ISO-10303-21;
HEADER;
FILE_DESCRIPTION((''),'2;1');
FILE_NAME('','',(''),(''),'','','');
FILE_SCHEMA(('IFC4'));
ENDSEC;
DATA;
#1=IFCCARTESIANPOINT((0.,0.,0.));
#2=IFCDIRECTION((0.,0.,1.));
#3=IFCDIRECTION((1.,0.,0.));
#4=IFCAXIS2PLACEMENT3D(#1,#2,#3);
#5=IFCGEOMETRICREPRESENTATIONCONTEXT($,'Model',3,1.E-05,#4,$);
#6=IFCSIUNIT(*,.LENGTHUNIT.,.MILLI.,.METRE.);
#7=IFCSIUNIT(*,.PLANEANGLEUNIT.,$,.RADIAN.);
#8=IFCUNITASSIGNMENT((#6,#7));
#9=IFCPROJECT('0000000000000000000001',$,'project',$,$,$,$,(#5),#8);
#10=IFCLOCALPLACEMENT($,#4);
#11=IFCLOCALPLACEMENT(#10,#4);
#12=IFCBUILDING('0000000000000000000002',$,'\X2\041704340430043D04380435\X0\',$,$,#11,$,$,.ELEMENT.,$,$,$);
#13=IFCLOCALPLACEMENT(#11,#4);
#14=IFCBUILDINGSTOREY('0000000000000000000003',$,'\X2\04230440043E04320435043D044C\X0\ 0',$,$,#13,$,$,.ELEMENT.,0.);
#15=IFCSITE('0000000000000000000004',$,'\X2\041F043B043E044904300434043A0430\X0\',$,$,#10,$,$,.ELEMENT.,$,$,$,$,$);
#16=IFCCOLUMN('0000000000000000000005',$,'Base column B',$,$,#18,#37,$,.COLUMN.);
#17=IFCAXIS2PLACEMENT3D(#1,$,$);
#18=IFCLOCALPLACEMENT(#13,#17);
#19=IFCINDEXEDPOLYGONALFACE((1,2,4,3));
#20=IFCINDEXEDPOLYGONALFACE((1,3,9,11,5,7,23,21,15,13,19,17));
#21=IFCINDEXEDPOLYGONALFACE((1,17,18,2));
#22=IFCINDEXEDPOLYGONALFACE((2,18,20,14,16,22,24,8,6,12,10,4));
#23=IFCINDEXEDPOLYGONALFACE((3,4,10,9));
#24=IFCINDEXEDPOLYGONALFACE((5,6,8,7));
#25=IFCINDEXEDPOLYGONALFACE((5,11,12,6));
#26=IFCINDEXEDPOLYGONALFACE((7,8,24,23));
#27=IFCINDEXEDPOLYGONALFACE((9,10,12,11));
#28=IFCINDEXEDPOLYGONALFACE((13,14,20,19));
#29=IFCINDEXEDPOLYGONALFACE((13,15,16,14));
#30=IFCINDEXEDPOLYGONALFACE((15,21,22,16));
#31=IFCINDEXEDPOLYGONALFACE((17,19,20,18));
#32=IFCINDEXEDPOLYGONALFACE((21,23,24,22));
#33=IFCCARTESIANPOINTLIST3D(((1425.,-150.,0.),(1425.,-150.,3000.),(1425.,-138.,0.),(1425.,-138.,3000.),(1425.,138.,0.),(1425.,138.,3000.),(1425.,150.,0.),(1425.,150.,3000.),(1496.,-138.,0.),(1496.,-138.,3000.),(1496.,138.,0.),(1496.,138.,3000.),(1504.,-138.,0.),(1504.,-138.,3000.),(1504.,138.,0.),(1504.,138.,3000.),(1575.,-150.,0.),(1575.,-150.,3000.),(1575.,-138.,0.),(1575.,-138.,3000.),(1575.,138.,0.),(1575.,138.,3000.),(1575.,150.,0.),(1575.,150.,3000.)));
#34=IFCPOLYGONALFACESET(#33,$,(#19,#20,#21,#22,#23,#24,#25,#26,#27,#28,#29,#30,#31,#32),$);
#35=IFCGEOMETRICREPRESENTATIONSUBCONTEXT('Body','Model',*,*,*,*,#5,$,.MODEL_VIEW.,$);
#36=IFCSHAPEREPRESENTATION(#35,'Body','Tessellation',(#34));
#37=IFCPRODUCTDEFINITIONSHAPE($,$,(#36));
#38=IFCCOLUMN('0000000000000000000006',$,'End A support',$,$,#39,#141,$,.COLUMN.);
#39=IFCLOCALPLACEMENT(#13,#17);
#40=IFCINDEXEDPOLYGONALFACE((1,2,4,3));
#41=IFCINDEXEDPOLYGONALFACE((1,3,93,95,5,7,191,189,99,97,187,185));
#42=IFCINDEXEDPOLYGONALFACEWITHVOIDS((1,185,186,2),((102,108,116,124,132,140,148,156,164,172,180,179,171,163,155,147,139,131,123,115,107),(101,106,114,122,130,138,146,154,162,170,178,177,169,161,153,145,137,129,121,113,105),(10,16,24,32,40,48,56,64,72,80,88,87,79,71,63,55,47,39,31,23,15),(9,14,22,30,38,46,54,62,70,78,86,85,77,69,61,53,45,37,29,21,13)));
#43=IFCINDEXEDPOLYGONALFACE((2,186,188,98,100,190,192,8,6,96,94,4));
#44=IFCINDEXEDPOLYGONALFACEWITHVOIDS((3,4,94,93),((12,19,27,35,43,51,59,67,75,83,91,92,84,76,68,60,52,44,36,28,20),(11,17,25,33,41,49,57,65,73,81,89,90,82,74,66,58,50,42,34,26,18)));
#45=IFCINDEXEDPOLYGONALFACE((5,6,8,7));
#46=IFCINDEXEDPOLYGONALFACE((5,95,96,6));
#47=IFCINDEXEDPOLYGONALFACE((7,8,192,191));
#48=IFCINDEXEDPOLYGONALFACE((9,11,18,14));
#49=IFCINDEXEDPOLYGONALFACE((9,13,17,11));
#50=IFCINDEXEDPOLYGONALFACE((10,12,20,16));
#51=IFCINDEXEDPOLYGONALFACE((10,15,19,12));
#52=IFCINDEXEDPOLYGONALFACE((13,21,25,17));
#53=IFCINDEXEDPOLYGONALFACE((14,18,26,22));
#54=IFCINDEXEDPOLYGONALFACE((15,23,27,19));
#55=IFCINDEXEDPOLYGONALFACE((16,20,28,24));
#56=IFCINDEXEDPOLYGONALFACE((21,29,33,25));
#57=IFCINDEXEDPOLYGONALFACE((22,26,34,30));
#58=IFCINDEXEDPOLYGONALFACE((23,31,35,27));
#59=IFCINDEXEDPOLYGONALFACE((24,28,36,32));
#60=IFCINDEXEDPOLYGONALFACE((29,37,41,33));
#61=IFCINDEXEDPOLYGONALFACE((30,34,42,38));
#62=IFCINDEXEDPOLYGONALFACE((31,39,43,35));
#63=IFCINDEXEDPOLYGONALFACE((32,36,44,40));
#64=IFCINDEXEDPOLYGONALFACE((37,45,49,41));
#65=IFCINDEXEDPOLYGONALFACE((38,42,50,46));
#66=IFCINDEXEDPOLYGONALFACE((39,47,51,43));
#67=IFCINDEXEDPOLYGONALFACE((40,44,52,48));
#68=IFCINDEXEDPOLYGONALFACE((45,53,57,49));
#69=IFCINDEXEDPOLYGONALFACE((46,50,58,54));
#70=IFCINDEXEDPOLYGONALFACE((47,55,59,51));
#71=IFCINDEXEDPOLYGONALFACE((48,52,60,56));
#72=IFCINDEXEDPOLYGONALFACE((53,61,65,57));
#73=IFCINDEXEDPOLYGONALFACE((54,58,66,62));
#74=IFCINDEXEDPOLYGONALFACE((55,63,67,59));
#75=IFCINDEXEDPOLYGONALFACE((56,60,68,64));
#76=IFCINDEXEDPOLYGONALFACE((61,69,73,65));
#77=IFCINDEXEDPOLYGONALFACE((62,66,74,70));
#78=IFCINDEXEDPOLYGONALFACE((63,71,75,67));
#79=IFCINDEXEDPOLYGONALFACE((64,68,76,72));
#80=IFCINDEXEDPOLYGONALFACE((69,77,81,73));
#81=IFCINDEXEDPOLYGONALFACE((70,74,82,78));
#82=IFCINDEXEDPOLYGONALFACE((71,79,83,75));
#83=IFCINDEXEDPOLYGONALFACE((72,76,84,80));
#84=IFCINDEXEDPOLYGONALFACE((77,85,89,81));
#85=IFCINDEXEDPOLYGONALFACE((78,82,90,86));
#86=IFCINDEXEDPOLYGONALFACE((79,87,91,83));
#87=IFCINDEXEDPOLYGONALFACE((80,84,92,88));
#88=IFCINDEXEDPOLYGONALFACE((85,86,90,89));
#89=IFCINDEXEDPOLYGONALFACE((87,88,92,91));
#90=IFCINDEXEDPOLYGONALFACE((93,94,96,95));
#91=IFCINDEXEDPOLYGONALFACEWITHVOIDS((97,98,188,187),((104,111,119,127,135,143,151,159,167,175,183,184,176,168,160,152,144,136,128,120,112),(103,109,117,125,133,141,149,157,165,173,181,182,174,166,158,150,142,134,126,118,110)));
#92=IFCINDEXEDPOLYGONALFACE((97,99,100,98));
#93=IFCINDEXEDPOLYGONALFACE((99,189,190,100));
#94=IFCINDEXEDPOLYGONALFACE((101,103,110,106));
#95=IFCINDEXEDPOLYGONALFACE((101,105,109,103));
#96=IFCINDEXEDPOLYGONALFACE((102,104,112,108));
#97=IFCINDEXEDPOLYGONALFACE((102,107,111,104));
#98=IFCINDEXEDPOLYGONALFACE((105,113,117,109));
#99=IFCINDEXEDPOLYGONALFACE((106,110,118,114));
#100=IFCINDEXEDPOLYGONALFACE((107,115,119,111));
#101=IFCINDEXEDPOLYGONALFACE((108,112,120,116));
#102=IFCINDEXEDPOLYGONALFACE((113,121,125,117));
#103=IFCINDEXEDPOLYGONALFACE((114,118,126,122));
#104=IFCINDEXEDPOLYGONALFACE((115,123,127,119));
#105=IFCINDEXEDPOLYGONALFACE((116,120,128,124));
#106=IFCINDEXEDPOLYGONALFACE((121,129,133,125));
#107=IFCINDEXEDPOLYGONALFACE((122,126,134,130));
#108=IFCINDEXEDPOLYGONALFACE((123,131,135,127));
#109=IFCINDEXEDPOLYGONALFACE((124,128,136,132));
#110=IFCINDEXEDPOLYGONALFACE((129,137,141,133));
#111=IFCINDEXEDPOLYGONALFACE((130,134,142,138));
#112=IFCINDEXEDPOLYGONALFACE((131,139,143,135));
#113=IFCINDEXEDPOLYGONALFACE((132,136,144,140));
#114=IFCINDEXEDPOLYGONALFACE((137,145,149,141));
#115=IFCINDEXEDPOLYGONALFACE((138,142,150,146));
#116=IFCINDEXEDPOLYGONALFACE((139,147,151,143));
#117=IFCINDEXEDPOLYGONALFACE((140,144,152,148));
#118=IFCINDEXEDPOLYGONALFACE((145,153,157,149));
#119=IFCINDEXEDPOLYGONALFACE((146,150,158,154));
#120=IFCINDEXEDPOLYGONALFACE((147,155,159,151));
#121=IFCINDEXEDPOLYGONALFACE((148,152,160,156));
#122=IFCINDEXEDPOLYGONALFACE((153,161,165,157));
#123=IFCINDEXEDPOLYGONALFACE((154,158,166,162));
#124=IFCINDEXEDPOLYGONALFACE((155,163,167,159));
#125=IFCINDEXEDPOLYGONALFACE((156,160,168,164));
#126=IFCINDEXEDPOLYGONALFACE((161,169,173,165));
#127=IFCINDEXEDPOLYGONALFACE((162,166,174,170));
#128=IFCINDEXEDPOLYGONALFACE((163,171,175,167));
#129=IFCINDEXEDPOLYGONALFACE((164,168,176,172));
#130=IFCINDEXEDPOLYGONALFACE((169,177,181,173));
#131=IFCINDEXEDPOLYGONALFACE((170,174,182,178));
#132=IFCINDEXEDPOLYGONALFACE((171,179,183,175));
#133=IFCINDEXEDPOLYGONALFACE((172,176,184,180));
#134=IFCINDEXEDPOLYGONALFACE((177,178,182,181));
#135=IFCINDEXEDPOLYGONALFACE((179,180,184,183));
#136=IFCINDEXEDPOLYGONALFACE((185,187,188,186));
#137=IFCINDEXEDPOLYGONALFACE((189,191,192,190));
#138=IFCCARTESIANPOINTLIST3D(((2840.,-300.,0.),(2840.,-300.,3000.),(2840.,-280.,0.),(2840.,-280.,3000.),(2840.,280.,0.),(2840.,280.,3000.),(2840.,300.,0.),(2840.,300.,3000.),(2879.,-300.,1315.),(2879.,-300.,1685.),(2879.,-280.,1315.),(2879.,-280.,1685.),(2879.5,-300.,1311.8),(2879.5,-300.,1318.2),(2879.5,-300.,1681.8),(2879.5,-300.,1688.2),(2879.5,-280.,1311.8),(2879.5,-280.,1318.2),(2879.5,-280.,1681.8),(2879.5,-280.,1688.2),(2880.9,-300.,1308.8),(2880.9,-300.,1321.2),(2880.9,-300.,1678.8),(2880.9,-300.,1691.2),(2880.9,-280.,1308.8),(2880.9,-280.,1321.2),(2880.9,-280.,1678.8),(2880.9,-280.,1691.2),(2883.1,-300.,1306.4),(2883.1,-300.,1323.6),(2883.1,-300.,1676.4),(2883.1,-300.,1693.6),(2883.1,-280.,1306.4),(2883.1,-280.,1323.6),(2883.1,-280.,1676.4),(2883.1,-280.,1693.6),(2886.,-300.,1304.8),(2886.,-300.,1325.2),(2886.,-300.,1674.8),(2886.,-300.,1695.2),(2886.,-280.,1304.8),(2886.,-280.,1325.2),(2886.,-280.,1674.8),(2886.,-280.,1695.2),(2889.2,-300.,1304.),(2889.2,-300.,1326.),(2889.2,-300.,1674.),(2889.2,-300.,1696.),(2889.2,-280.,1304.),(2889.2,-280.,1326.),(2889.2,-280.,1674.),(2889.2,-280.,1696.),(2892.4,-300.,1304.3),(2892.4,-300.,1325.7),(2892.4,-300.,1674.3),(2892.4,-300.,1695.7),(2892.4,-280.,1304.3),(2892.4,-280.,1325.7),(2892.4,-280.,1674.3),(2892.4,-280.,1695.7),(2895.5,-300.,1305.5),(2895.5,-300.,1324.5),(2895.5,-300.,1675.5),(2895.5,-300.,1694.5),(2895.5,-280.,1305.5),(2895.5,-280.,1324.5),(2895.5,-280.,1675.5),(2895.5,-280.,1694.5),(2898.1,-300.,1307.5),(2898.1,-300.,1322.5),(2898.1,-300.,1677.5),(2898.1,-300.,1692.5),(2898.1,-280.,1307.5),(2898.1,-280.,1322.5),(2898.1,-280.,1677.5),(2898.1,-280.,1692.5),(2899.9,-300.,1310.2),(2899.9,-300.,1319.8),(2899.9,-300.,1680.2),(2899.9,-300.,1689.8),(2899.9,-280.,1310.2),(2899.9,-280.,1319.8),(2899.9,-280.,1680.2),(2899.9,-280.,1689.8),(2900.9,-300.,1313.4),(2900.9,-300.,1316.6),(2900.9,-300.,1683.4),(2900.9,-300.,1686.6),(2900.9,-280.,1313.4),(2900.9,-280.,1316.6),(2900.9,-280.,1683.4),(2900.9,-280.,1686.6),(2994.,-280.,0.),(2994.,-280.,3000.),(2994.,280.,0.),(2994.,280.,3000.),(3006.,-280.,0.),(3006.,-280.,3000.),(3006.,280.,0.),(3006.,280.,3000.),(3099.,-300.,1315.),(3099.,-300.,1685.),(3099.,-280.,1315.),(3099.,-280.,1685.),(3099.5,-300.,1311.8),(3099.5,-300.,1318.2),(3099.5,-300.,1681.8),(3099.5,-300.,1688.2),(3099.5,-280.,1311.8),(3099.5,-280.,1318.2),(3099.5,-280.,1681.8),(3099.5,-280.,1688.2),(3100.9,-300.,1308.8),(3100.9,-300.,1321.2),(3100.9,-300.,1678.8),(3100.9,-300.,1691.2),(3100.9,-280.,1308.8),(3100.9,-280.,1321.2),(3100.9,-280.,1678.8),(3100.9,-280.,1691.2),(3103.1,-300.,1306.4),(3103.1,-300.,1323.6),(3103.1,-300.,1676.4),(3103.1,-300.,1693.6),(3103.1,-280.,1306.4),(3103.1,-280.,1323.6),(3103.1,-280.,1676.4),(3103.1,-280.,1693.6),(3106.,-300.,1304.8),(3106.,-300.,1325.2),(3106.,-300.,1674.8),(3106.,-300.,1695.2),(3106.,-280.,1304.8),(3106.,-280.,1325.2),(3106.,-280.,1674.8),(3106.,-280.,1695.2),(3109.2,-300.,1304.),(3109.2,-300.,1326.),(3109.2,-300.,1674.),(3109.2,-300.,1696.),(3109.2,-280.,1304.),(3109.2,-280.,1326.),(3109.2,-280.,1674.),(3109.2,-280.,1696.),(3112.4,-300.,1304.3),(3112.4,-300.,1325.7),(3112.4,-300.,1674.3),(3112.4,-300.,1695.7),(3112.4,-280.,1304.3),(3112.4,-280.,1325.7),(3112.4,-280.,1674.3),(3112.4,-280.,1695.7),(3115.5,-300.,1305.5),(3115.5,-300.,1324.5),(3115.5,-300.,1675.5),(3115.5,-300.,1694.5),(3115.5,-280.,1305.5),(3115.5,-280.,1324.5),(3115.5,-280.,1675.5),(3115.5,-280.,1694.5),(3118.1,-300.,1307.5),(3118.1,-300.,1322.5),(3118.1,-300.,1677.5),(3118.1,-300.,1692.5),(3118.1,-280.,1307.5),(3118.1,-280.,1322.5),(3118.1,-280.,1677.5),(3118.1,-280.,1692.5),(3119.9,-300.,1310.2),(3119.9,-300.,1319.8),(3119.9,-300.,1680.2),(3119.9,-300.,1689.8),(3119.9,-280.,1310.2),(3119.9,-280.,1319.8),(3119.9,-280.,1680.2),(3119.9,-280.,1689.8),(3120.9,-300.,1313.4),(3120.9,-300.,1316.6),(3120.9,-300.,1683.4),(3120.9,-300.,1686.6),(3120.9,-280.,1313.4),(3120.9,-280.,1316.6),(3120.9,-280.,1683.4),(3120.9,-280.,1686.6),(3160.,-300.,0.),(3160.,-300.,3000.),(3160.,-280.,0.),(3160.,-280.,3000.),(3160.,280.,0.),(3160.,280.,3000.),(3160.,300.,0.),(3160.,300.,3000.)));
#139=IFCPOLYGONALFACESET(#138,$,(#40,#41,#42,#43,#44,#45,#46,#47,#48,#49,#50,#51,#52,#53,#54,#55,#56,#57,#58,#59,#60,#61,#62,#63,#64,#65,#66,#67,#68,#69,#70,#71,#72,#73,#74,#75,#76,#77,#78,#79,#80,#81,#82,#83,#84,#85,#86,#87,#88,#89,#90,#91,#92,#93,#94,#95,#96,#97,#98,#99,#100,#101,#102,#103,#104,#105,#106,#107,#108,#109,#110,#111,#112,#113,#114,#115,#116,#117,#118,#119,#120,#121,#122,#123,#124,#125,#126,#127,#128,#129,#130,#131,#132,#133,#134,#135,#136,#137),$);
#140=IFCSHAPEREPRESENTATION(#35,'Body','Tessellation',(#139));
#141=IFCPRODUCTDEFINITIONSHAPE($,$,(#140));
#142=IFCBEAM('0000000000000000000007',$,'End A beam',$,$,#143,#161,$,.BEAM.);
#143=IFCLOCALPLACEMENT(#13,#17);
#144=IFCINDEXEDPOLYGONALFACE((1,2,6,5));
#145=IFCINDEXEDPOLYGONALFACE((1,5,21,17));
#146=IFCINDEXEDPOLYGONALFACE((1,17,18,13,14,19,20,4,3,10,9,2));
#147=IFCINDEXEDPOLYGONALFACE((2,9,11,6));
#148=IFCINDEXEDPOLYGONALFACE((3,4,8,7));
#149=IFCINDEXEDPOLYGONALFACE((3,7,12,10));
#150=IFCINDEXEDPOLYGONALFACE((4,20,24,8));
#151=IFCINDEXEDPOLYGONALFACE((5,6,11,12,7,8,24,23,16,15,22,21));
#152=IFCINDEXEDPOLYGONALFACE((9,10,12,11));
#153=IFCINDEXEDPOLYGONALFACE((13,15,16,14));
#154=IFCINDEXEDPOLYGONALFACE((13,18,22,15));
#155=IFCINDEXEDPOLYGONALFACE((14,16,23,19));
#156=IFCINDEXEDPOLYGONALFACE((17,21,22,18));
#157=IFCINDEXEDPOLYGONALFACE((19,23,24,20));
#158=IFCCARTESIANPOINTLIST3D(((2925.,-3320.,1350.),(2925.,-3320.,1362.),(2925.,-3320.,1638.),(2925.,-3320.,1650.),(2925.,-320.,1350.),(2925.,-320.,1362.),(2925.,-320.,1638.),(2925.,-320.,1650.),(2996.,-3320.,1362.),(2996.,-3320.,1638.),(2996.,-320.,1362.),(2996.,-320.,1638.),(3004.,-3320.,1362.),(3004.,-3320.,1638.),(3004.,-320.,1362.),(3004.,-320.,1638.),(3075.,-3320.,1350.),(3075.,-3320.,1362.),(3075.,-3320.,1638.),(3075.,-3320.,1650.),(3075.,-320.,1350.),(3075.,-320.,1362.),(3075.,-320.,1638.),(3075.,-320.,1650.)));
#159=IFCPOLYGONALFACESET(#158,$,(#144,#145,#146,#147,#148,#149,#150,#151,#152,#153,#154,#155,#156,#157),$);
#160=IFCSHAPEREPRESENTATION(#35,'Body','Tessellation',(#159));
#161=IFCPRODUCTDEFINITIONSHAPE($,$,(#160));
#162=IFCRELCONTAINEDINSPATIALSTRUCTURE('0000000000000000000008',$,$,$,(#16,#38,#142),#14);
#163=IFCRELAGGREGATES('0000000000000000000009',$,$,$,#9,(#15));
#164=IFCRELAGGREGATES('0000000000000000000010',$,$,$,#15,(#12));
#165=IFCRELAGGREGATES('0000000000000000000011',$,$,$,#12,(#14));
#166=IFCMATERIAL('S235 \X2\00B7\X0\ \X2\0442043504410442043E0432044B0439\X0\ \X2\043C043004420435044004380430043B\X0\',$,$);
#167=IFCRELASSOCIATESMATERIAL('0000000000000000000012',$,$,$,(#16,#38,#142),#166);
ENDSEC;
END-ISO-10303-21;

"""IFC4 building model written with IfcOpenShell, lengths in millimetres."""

from ifc_helpers import new_model, si_unit, frame, origin_with_axes, place, context, subcontext, project, spatial, circle, i_section, extrude, material, element, save


model = new_model("IFC4")

# Units and contexts
model_context = context("Model", 3, precision=1e-05, world=origin_with_axes())
body_context = subcontext(model_context, "Body", "Model", "MODEL_VIEW")
ifc_project = project(units=[si_unit("LENGTHUNIT", "METRE", prefix="MILLI"), si_unit("PLANEANGLEUNIT", "RADIAN")], contexts=[model_context])

# Site, building, storey
site_placement = place(None, origin_with_axes())
site = spatial("IfcSite", under=ifc_project, at=site_placement, Name="Площадка", CompositionType="ELEMENT")
building_placement = place(site_placement, origin_with_axes())
building = spatial("IfcBuilding", under=site, at=building_placement, Name="Здание", CompositionType="ELEMENT")
storey_placement = place(building_placement, origin_with_axes())
storey = spatial("IfcBuildingStorey", under=building, at=storey_placement, Name="Уровень 0", CompositionType="ELEMENT", Elevation=0.0)

# Column
ifc_material = material(Name="S235 · тестовый материал")
column_1_placement = place(storey_placement, frame((1500.0, 0.0, 0.0), z_axis=(0.0, 0.0, 1.0), x_axis=(1.0, 0.0, 0.0)))
element("IfcColumn", 1, at=column_1_placement, inside=storey, material=ifc_material, Name="Base column B", PredefinedType="COLUMN", context=body_context, shape_type="SweptSolid", body=[
    extrude(i_section(OverallWidth=150.0, OverallDepth=300.0, WebThickness=8.0, FlangeThickness=12.0), origin_with_axes(), (0.0, 0.0, 1.0), 3000.0),
])

# Column, openings
column_2_placement = place(storey_placement, frame((3000.0, 0.0, 0.0), z_axis=(0.0, 0.0, 1.0), x_axis=(1.0, 0.0, 0.0)))
column_2 = element("IfcColumn", 2, at=column_2_placement, inside=storey, material=ifc_material, Name="End A support", PredefinedType="COLUMN", context=body_context, shape_type="SweptSolid", body=[
    extrude(i_section(OverallWidth=320.0, OverallDepth=600.0, WebThickness=12.0, FlangeThickness=20.0), origin_with_axes(), (0.0, 0.0, 1.0), 3000.0),
])
opening_1_placement = place(column_2_placement, frame((110.0, -321.0, 1315.0), z_axis=(0.0, 1.0, 0.0), x_axis=(-1.0, 0.0, 0.0)))
element("IfcOpeningElement", 3, at=opening_1_placement, cuts=column_2, PredefinedType="OPENING", context=body_context, shape_type="SweptSolid", body=[
    extrude(circle(Radius=11.0), origin_with_axes(), (0.0, 0.0, 1.0), 42.0),
])
opening_2_placement = place(column_2_placement, frame((110.0, -321.0, 1685.0), z_axis=(0.0, 1.0, 0.0), x_axis=(-1.0, 0.0, 0.0)))
element("IfcOpeningElement", 4, at=opening_2_placement, cuts=column_2, PredefinedType="OPENING", context=body_context, shape_type="SweptSolid", body=[
    extrude(circle(Radius=11.0), origin_with_axes(), (0.0, 0.0, 1.0), 42.0),
])
opening_3_placement = place(column_2_placement, frame((-110.0, -321.0, 1315.0), z_axis=(0.0, 1.0, 0.0), x_axis=(-1.0, 0.0, 0.0)))
element("IfcOpeningElement", 5, at=opening_3_placement, cuts=column_2, PredefinedType="OPENING", context=body_context, shape_type="SweptSolid", body=[
    extrude(circle(Radius=11.0), origin_with_axes(), (0.0, 0.0, 1.0), 42.0),
])
opening_4_placement = place(column_2_placement, frame((-110.0, -321.0, 1685.0), z_axis=(0.0, 1.0, 0.0), x_axis=(-1.0, 0.0, 0.0)))
element("IfcOpeningElement", 6, at=opening_4_placement, cuts=column_2, PredefinedType="OPENING", context=body_context, shape_type="SweptSolid", body=[
    extrude(circle(Radius=11.0), origin_with_axes(), (0.0, 0.0, 1.0), 42.0),
])

# Beam
beam_1_placement = place(storey_placement, frame((3000.0, -3320.0, 1500.0), z_axis=(0.0, 1.0, 0.0), x_axis=(-1.0, 0.0, 0.0)))
element("IfcBeam", 7, at=beam_1_placement, inside=storey, material=ifc_material, Name="End A beam", PredefinedType="BEAM", context=body_context, shape_type="SweptSolid", body=[
    extrude(i_section(OverallWidth=150.0, OverallDepth=300.0, WebThickness=8.0, FlangeThickness=12.0), origin_with_axes(), (0.0, 0.0, 1.0), 3000.0),
])

save(model, "model.ifc")
